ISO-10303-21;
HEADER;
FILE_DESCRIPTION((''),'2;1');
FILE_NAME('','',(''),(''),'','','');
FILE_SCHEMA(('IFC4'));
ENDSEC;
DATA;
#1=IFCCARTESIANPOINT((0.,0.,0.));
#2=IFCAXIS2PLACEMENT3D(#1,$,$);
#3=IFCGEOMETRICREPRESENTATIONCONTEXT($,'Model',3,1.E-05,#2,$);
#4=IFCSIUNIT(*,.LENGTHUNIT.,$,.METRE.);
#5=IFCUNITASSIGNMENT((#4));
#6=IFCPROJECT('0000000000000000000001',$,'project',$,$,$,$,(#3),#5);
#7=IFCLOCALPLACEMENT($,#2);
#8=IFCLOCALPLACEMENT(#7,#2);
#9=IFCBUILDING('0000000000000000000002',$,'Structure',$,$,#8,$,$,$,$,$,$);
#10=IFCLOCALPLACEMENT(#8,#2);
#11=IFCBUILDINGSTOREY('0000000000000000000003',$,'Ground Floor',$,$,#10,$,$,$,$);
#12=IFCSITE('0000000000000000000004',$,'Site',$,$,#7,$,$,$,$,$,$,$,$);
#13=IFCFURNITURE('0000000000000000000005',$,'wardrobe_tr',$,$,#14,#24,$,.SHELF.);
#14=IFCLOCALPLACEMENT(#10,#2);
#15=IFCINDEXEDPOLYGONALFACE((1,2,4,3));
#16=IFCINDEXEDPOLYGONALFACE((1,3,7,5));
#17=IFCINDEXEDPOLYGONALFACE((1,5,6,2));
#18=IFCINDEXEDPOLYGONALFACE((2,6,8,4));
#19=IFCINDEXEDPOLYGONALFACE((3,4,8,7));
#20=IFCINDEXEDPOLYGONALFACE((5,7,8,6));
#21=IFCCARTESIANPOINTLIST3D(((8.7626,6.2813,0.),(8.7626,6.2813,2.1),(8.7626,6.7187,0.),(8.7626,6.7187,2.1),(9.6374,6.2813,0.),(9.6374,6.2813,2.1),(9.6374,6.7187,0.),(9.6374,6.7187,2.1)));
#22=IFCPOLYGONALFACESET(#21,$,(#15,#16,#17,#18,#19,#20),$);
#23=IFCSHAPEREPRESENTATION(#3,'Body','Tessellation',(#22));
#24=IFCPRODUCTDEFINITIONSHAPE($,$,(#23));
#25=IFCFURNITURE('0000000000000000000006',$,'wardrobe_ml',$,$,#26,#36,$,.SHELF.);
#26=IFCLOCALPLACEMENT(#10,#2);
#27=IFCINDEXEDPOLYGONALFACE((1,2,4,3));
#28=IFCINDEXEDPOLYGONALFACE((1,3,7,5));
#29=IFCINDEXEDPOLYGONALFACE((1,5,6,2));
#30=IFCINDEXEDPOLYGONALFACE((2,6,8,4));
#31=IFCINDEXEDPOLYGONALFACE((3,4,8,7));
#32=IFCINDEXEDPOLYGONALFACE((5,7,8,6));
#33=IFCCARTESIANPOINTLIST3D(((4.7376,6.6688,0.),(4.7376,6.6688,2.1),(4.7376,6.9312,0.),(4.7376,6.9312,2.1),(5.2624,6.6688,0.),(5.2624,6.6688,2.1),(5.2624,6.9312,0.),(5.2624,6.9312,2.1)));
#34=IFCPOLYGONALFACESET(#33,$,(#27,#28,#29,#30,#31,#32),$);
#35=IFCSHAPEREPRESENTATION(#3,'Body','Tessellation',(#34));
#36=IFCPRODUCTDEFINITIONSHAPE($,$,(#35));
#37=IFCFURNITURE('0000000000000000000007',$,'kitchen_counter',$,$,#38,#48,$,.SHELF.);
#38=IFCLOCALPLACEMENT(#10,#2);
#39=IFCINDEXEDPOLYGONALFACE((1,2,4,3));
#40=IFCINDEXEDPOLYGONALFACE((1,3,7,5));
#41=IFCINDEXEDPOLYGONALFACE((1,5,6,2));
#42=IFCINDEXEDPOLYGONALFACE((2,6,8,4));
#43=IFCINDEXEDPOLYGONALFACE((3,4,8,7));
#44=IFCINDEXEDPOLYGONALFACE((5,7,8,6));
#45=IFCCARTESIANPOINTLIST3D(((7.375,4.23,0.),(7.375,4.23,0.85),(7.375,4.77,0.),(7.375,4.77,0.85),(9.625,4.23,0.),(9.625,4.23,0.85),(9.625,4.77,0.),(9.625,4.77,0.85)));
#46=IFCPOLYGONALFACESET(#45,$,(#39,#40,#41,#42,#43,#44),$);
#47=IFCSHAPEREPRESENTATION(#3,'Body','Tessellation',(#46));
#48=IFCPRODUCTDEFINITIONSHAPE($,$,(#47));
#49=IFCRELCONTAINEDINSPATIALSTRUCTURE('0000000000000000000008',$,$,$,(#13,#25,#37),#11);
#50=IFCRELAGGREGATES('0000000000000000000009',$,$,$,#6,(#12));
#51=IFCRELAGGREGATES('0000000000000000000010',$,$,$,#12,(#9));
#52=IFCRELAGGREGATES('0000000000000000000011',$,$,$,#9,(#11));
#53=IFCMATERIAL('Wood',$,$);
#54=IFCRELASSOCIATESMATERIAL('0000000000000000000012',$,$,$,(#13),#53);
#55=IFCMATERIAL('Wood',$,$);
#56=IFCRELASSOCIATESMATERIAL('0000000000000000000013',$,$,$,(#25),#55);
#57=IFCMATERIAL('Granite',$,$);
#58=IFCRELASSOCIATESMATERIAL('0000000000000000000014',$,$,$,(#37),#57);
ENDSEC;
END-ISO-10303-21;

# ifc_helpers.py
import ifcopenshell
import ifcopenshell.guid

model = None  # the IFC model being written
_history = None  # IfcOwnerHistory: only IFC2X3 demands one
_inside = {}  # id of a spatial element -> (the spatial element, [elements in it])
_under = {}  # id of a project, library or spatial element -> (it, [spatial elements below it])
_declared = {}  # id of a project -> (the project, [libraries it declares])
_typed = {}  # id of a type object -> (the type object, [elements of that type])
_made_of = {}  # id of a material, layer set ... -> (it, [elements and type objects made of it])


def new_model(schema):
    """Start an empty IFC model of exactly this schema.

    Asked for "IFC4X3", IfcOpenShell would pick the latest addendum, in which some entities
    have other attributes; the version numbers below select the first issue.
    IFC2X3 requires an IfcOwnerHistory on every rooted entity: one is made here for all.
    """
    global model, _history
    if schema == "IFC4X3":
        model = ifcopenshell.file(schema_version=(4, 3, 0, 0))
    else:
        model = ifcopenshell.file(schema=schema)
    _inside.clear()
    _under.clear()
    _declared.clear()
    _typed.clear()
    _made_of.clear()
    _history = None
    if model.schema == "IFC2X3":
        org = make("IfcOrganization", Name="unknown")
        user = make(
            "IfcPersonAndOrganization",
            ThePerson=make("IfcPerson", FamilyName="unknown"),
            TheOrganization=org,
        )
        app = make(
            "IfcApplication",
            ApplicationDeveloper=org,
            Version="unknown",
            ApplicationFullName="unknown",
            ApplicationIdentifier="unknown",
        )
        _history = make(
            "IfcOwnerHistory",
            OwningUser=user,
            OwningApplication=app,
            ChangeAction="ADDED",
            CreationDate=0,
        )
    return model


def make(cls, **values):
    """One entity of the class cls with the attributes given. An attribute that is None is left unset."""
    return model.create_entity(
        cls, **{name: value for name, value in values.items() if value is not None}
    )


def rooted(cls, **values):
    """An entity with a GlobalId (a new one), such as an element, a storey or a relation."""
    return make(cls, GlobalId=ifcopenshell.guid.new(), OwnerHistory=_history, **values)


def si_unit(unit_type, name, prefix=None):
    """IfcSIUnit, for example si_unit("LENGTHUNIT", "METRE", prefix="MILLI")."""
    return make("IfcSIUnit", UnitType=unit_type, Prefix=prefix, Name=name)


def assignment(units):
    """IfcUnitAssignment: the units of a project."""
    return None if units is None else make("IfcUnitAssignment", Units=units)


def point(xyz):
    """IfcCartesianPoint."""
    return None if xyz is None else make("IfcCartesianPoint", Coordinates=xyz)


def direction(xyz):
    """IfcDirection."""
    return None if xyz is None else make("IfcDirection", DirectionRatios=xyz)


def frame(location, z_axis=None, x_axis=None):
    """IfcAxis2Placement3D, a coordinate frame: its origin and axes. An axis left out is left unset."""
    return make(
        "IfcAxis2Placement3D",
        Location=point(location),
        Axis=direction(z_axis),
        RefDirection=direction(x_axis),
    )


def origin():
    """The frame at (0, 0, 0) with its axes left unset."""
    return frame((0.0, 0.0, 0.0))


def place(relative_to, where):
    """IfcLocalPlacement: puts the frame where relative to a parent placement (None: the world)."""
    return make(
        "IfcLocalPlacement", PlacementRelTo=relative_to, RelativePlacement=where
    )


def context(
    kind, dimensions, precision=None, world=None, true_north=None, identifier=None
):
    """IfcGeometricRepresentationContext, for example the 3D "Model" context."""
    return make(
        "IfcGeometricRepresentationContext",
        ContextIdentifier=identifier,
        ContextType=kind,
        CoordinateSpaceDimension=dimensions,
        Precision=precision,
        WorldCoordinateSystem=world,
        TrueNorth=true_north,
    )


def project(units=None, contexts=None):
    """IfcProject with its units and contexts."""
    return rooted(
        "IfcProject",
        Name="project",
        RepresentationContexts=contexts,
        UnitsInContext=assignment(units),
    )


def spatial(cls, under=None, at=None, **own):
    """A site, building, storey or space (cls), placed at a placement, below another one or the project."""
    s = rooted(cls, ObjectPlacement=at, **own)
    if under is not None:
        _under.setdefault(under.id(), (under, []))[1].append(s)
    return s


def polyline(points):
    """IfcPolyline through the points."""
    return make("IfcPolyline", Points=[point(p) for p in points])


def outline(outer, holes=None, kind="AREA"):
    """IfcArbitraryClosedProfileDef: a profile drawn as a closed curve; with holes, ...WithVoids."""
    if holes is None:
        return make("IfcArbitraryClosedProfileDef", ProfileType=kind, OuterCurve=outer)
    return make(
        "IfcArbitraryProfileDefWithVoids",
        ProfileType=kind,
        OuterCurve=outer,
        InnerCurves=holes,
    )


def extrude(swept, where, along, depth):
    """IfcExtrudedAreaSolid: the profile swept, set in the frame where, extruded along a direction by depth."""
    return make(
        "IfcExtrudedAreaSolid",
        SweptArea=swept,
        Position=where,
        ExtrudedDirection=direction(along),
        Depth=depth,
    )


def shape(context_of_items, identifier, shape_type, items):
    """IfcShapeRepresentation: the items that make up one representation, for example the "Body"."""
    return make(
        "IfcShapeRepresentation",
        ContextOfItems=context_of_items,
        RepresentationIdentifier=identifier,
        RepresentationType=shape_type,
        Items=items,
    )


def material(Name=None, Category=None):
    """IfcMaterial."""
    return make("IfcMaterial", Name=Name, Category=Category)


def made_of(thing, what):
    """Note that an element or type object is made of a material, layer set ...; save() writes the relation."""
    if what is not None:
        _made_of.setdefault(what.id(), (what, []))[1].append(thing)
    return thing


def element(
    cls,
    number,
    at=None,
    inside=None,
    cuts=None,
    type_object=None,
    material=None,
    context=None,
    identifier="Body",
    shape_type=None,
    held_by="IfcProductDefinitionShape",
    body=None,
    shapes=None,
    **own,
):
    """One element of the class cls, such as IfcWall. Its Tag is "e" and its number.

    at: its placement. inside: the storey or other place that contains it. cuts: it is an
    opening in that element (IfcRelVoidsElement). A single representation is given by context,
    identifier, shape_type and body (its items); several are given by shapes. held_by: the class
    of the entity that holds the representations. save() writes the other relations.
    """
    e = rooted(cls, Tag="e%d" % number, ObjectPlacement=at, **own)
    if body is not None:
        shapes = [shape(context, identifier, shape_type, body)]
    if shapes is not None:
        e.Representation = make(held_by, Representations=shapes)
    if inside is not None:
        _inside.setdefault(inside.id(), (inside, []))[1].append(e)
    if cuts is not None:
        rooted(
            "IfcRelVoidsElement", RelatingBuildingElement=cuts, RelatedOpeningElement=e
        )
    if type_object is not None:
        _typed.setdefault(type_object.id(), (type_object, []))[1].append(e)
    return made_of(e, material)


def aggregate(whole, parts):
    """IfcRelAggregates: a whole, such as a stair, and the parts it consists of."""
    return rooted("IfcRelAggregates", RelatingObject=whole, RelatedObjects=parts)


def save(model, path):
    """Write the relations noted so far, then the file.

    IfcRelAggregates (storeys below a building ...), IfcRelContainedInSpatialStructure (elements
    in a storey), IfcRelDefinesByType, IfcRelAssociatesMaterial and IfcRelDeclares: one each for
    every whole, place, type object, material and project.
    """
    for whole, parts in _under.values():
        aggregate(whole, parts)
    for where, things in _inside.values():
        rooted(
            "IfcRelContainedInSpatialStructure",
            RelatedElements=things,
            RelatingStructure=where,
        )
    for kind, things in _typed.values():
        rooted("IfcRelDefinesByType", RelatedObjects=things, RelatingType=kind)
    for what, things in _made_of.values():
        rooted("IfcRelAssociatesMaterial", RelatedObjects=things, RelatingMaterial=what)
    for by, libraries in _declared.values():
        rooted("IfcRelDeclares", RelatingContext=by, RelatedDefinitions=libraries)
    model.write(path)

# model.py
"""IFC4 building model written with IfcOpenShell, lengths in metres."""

from ifc_helpers import new_model, si_unit, frame, origin, place, context, project, spatial, polyline, outline, extrude, material, element, save


model = new_model("IFC4")

# Units and contexts
model_context = context("Model", 3, precision=1e-05, world=origin())
ifc_project = project(units=[si_unit("LENGTHUNIT", "METRE")], contexts=[model_context])

# Site, building, storey
site_placement = place(None, origin())
site = spatial("IfcSite", under=ifc_project, at=site_placement, Name="Site")
building_placement = place(site_placement, origin())
building = spatial("IfcBuilding", under=site, at=building_placement, Name="Structure")
storey_placement = place(building_placement, origin())
storey = spatial("IfcBuildingStorey", under=building, at=storey_placement, Name="Ground Floor")

# Furniture
ifc_material_1 = material(Name="Wood")
furniture_1_placement = place(storey_placement, frame((9.2, 6.5, 0.0)))
element("IfcFurniture", 1, at=furniture_1_placement, inside=storey, material=ifc_material_1, Name="wardrobe_tr", PredefinedType="SHELF", context=model_context, shape_type="SweptSolid", body=[
    extrude(outline(polyline([(-0.4374, -0.2187), (0.4374, -0.2187), (0.4374, 0.2187), (-0.4374, 0.2187), (-0.4374, -0.2187)])), origin(), (0.0, 0.0, 1.0), 2.1),
])
ifc_material_2 = material(Name="Wood")
furniture_2_placement = place(storey_placement, frame((5.0, 6.8, 0.0)))
element("IfcFurniture", 2, at=furniture_2_placement, inside=storey, material=ifc_material_2, Name="wardrobe_ml", PredefinedType="SHELF", context=model_context, shape_type="SweptSolid", body=[
    extrude(outline(polyline([(-0.2624, -0.1312), (0.2624, -0.1312), (0.2624, 0.1312), (-0.2624, 0.1312), (-0.2624, -0.1312)])), origin(), (0.0, 0.0, 1.0), 2.1),
])
ifc_material_3 = material(Name="Granite")
furniture_3_placement = place(storey_placement, frame((8.5, 4.5, 0.0)))
element("IfcFurniture", 3, at=furniture_3_placement, inside=storey, material=ifc_material_3, Name="kitchen_counter", PredefinedType="SHELF", context=model_context, shape_type="SweptSolid", body=[
    extrude(outline(polyline([(-1.125, -0.27), (1.125, -0.27), (1.125, 0.27), (-1.125, 0.27), (-1.125, -0.27)])), origin(), (0.0, 0.0, 1.0), 0.85),
])

save(model, "model.ifc")
